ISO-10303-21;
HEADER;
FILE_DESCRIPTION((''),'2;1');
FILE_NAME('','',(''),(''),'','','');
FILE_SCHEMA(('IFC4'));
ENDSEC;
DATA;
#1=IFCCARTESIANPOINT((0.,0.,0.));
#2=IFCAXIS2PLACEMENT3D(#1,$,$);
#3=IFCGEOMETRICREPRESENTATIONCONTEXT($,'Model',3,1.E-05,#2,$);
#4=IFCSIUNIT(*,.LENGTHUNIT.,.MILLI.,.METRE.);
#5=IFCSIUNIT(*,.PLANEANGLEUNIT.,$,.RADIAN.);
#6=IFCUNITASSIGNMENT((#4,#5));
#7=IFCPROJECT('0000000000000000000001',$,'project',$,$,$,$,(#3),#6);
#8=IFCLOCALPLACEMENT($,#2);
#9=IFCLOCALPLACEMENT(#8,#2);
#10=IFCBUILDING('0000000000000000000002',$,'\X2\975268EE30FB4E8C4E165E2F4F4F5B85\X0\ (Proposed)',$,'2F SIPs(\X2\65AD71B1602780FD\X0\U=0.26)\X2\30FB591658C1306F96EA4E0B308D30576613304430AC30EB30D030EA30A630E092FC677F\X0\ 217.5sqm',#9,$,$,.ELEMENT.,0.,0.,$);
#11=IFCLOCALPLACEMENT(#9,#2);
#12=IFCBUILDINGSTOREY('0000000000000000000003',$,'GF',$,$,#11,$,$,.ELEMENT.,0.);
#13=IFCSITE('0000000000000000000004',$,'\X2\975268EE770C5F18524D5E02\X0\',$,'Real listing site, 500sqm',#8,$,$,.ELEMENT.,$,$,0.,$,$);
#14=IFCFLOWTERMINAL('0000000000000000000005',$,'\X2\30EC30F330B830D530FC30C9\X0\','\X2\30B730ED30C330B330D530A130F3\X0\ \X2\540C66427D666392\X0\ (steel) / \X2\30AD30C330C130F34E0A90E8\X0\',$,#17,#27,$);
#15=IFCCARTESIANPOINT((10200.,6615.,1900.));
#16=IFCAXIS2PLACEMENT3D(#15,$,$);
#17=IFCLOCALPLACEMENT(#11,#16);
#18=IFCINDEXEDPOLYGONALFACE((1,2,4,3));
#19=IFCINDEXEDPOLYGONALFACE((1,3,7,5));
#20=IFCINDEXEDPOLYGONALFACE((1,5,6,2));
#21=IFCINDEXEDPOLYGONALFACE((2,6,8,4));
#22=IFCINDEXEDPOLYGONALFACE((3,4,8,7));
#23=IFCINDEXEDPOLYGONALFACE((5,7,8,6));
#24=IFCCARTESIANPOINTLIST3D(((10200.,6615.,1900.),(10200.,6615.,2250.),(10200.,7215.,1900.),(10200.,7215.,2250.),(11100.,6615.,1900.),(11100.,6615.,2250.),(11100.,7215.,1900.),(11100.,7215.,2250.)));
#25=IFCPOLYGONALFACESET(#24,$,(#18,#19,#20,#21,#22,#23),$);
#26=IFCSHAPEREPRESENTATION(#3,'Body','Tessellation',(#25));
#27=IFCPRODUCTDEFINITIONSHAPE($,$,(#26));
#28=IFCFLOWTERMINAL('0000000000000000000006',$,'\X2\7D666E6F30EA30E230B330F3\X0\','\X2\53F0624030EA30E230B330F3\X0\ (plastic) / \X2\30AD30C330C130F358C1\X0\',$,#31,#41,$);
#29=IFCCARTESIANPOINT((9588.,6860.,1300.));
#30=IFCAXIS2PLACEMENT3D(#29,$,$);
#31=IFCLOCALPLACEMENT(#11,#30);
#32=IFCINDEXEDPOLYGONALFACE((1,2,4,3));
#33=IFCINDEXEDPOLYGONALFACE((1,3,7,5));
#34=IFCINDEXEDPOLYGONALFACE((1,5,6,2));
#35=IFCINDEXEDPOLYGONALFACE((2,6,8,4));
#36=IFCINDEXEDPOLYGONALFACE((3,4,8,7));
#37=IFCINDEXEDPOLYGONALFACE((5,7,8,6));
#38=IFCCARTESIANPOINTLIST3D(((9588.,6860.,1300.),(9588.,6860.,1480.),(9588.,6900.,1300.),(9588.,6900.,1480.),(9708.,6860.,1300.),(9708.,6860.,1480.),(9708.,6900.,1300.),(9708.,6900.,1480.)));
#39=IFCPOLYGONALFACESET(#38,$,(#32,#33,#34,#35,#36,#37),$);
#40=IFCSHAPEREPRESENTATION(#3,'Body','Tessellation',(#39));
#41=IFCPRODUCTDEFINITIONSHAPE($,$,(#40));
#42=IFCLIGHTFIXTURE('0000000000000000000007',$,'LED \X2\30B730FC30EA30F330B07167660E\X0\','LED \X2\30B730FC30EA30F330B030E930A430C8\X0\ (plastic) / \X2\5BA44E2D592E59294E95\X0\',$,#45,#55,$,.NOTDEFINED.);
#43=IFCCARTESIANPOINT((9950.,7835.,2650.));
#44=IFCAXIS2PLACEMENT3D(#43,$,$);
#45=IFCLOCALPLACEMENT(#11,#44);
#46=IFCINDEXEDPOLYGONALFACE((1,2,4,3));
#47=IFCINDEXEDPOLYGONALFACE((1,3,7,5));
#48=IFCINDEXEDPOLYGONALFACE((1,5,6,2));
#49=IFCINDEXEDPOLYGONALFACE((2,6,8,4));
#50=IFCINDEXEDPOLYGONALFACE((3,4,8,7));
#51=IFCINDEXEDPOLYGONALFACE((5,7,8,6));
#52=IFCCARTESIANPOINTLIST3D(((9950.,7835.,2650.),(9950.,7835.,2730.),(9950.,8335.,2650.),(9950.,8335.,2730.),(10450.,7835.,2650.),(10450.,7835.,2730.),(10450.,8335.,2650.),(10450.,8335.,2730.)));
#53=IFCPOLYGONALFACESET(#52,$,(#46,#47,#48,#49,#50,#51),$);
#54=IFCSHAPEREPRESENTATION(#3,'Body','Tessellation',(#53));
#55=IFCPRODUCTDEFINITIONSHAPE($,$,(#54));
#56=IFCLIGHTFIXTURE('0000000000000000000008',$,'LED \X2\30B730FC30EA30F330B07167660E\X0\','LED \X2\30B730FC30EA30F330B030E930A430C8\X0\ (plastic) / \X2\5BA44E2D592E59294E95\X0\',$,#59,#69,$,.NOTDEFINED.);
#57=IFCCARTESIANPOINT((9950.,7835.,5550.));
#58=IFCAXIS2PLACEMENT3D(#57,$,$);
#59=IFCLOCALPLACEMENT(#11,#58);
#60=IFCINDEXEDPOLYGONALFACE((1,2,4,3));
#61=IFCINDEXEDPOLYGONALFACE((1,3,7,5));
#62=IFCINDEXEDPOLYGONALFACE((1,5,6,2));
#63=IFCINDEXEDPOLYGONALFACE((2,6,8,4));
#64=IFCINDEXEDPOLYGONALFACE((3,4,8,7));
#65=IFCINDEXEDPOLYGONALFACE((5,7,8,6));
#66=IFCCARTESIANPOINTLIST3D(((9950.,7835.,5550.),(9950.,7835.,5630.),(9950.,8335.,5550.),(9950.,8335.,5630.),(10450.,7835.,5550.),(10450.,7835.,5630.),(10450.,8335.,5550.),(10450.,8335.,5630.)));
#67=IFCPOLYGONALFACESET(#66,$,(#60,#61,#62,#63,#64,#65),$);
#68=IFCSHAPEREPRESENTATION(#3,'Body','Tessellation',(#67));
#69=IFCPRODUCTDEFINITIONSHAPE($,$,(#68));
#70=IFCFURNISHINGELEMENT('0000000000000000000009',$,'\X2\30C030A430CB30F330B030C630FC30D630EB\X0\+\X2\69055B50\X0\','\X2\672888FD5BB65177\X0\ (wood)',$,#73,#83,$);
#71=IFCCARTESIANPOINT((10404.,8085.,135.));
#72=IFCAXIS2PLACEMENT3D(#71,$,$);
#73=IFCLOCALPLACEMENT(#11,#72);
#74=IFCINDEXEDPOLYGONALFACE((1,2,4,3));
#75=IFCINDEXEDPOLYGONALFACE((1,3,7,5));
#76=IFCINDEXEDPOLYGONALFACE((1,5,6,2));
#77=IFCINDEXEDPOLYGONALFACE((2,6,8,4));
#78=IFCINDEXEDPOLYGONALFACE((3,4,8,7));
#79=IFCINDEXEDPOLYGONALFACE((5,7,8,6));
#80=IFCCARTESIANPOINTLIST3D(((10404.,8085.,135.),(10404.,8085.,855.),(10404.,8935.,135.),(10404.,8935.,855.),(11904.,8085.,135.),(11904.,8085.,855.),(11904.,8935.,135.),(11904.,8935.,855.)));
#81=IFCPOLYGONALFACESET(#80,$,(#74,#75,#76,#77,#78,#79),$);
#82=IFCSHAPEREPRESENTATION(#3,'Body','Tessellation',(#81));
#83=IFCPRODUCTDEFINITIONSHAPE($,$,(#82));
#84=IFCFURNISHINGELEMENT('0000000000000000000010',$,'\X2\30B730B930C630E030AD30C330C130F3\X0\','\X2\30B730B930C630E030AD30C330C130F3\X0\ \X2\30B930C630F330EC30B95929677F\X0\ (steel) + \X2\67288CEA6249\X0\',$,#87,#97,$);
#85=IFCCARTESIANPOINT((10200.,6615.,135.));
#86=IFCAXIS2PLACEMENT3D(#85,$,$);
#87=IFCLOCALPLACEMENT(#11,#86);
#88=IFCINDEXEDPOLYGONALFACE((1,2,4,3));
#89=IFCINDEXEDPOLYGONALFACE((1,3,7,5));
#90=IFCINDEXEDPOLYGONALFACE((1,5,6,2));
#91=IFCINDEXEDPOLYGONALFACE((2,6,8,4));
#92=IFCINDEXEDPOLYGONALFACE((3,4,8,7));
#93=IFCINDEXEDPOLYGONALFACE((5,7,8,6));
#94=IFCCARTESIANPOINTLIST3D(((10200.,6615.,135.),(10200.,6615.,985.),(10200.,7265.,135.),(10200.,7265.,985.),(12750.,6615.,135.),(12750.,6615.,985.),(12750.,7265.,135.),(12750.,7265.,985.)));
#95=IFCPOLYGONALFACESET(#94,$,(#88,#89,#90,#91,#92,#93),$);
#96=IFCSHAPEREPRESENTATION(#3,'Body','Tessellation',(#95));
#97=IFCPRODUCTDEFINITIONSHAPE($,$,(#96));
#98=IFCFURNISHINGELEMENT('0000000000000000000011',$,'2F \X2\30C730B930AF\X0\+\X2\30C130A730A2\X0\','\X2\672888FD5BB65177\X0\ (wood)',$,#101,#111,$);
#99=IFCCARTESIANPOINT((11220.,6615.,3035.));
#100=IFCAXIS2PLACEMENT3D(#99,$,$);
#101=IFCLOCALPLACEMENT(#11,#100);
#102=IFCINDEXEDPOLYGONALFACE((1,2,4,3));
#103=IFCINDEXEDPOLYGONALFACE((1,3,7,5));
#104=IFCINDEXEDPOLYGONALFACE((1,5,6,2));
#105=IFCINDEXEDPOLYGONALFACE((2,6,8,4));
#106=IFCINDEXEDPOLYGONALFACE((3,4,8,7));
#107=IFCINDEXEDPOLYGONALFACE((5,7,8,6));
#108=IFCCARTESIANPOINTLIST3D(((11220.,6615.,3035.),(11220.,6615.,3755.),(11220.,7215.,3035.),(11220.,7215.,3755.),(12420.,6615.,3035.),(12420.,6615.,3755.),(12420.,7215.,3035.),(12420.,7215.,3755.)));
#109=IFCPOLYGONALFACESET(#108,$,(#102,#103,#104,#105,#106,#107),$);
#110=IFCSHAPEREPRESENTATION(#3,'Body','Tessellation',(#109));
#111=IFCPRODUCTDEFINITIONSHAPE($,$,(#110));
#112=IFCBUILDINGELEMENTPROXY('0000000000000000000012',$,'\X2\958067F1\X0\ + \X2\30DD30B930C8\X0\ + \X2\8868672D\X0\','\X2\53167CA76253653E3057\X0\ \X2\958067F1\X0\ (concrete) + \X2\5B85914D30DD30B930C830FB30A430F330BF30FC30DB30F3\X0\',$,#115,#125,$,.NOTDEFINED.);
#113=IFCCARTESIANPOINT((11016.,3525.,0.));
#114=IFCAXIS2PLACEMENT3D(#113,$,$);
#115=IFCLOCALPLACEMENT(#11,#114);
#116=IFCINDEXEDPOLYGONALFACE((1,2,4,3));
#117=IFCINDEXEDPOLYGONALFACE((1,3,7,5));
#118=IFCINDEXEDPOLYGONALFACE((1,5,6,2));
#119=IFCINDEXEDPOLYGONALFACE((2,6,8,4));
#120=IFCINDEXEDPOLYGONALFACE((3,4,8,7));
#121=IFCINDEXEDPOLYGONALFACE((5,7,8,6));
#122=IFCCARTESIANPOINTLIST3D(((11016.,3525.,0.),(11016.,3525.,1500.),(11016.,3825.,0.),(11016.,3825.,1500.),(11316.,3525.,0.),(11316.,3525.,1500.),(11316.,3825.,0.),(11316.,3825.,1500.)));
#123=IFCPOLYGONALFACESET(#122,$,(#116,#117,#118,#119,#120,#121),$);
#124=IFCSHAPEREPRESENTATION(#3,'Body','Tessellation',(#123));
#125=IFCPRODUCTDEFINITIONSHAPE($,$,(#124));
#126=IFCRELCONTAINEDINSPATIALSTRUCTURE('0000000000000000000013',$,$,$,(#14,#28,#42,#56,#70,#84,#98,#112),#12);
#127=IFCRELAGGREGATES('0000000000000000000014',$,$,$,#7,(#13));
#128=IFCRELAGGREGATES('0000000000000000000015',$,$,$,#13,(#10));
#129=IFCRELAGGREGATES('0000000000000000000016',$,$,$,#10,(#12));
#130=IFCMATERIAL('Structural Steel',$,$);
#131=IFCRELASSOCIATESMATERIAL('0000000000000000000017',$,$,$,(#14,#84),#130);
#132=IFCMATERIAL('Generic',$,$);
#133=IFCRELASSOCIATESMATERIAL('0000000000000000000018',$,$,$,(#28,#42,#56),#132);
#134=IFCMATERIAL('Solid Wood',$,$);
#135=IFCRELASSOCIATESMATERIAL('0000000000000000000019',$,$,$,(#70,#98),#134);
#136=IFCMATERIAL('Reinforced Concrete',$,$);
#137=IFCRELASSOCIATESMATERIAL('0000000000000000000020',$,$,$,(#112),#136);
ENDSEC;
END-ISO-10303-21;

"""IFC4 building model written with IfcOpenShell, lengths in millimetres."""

from ifc_helpers import new_model, si_unit, frame, frame_2d, origin, place, context, project, spatial, rectangle, extrude, material, element, save


model = new_model("IFC4")

# Units and contexts
model_context = context("Model", 3, precision=1e-05, world=origin())
ifc_project = project(units=[si_unit("LENGTHUNIT", "METRE", prefix="MILLI"), si_unit("PLANEANGLEUNIT", "RADIAN")], contexts=[model_context])

# Site, building, storey
site_placement = place(None, origin())
site = spatial("IfcSite", under=ifc_project, at=site_placement, Name="青森県弘前市", ObjectType="Real listing site, 500sqm", CompositionType="ELEMENT", RefElevation=0.0)
building_placement = place(site_placement, origin())
building = spatial("IfcBuilding", under=site, at=building_placement, Name="青森・二世帯住宅 (Proposed)", ObjectType="2F SIPs(断熱性能U=0.26)・外壁は雪下ろし易いガルバリウム鋼板 217.5sqm", CompositionType="ELEMENT", ElevationOfRefHeight=0.0, ElevationOfTerrain=0.0)
storey_placement = place(building_placement, origin())
storey = spatial("IfcBuildingStorey", under=building, at=storey_placement, Name="GF", CompositionType="ELEMENT", Elevation=0.0)

# Shared definitions
ifc_material_1 = material(Name="Solid Wood")

# Shared definitions
ifc_material_2 = material(Name="Structural Steel")

# Shared definitions
ifc_material_3 = material(Name="Reinforced Concrete")

# Flow terminals
flow_terminal_1_placement = place(storey_placement, frame((10200.0, 6615.0, 1900.0)))
element("IfcFlowTerminal", 1, at=flow_terminal_1_placement, inside=storey, material=ifc_material_2, Name="レンジフード", Description="シロッコファン 同時給排 (steel) / キッチン上部", context=model_context, shape_type="SweptSolid", body=[
    extrude(rectangle(XDim=900.0, YDim=600.0, at=frame_2d((450.0, 300.0))), frame((10200.0, 6615.0, 1900.0)), (0.0, 0.0, 1.0), 350.0),
])
ifc_material_4 = material(Name="Generic")
flow_terminal_2_placement = place(storey_placement, frame((9588.0, 6860.0, 1300.0)))
element("IfcFlowTerminal", 2, at=flow_terminal_2_placement, inside=storey, material=ifc_material_4, Name="給湯リモコン", Description="台所リモコン (plastic) / キッチン壁", context=model_context, shape_type="SweptSolid", body=[
    extrude(rectangle(XDim=120.0, YDim=40.0, at=frame_2d((60.0, 20.0))), frame((9588.0, 6860.0, 1300.0)), (0.0, 0.0, 1.0), 180.0),
])

# Light fixtures
light_fixture_1_placement = place(storey_placement, frame((9950.0, 7835.0, 2650.0)))
element("IfcLightFixture", 3, at=light_fixture_1_placement, inside=storey, material=ifc_material_4, Name="LED シーリング照明", Description="LED シーリングライト (plastic) / 室中央天井", PredefinedType="NOTDEFINED", context=model_context, shape_type="SweptSolid", body=[
    extrude(rectangle(XDim=500.0, YDim=500.0, at=frame_2d((250.0, 250.0))), frame((9950.0, 7835.0, 2650.0)), (0.0, 0.0, 1.0), 80.0),
])
light_fixture_2_placement = place(storey_placement, frame((9950.0, 7835.0, 5550.0)))
element("IfcLightFixture", 4, at=light_fixture_2_placement, inside=storey, material=ifc_material_4, Name="LED シーリング照明", Description="LED シーリングライト (plastic) / 室中央天井", PredefinedType="NOTDEFINED", context=model_context, shape_type="SweptSolid", body=[
    extrude(rectangle(XDim=500.0, YDim=500.0, at=frame_2d((250.0, 250.0))), frame((9950.0, 7835.0, 5550.0)), (0.0, 0.0, 1.0), 80.0),
])

# Furnishing elements
furnishing_1_placement = place(storey_placement, frame((10404.0, 8085.0, 135.0)))
element("IfcFurnishingElement", 5, at=furnishing_1_placement, inside=storey, material=ifc_material_1, Name="ダイニングテーブル+椅子", Description="木製家具 (wood)", context=model_context, shape_type="SweptSolid", body=[
    extrude(rectangle(XDim=1500.0, YDim=850.0, at=frame_2d((750.0, 425.0))), frame((10404.0, 8085.0, 135.0)), (0.0, 0.0, 1.0), 720.0),
])
furnishing_2_placement = place(storey_placement, frame((10200.0, 6615.0, 135.0)))
element("IfcFurnishingElement", 6, at=furnishing_2_placement, inside=storey, material=ifc_material_2, Name="システムキッチン", Description="システムキッチン ステンレス天板 (steel) + 木質扉", context=model_context, shape_type="SweptSolid", body=[
    extrude(rectangle(XDim=2550.0, YDim=650.0, at=frame_2d((1275.0, 325.0))), frame((10200.0, 6615.0, 135.0)), (0.0, 0.0, 1.0), 850.0),
])
furnishing_3_placement = place(storey_placement, frame((11220.0, 6615.0, 3035.0)))
element("IfcFurnishingElement", 7, at=furnishing_3_placement, inside=storey, material=ifc_material_1, Name="2F デスク+チェア", Description="木製家具 (wood)", context=model_context, shape_type="SweptSolid", body=[
    extrude(rectangle(XDim=1200.0, YDim=600.0, at=frame_2d((600.0, 300.0))), frame((11220.0, 6615.0, 3035.0)), (0.0, 0.0, 1.0), 720.0),
])

# Building element proxy
proxy_placement = place(storey_placement, frame((11016.0, 3525.0, 0.0)))
element("IfcBuildingElementProxy", 8, at=proxy_placement, inside=storey, material=ifc_material_3, Name="門柱 + ポスト + 表札", Description="化粧打放し 門柱 (concrete) + 宅配ポスト・インターホン", PredefinedType="NOTDEFINED", context=model_context, shape_type="SweptSolid", body=[
    extrude(rectangle(XDim=300.0, YDim=300.0, at=frame_2d((150.0, 150.0))), frame((11016.0, 3525.0, 0.0)), (0.0, 0.0, 1.0), 1500.0),
])

save(model, "model.ifc")
